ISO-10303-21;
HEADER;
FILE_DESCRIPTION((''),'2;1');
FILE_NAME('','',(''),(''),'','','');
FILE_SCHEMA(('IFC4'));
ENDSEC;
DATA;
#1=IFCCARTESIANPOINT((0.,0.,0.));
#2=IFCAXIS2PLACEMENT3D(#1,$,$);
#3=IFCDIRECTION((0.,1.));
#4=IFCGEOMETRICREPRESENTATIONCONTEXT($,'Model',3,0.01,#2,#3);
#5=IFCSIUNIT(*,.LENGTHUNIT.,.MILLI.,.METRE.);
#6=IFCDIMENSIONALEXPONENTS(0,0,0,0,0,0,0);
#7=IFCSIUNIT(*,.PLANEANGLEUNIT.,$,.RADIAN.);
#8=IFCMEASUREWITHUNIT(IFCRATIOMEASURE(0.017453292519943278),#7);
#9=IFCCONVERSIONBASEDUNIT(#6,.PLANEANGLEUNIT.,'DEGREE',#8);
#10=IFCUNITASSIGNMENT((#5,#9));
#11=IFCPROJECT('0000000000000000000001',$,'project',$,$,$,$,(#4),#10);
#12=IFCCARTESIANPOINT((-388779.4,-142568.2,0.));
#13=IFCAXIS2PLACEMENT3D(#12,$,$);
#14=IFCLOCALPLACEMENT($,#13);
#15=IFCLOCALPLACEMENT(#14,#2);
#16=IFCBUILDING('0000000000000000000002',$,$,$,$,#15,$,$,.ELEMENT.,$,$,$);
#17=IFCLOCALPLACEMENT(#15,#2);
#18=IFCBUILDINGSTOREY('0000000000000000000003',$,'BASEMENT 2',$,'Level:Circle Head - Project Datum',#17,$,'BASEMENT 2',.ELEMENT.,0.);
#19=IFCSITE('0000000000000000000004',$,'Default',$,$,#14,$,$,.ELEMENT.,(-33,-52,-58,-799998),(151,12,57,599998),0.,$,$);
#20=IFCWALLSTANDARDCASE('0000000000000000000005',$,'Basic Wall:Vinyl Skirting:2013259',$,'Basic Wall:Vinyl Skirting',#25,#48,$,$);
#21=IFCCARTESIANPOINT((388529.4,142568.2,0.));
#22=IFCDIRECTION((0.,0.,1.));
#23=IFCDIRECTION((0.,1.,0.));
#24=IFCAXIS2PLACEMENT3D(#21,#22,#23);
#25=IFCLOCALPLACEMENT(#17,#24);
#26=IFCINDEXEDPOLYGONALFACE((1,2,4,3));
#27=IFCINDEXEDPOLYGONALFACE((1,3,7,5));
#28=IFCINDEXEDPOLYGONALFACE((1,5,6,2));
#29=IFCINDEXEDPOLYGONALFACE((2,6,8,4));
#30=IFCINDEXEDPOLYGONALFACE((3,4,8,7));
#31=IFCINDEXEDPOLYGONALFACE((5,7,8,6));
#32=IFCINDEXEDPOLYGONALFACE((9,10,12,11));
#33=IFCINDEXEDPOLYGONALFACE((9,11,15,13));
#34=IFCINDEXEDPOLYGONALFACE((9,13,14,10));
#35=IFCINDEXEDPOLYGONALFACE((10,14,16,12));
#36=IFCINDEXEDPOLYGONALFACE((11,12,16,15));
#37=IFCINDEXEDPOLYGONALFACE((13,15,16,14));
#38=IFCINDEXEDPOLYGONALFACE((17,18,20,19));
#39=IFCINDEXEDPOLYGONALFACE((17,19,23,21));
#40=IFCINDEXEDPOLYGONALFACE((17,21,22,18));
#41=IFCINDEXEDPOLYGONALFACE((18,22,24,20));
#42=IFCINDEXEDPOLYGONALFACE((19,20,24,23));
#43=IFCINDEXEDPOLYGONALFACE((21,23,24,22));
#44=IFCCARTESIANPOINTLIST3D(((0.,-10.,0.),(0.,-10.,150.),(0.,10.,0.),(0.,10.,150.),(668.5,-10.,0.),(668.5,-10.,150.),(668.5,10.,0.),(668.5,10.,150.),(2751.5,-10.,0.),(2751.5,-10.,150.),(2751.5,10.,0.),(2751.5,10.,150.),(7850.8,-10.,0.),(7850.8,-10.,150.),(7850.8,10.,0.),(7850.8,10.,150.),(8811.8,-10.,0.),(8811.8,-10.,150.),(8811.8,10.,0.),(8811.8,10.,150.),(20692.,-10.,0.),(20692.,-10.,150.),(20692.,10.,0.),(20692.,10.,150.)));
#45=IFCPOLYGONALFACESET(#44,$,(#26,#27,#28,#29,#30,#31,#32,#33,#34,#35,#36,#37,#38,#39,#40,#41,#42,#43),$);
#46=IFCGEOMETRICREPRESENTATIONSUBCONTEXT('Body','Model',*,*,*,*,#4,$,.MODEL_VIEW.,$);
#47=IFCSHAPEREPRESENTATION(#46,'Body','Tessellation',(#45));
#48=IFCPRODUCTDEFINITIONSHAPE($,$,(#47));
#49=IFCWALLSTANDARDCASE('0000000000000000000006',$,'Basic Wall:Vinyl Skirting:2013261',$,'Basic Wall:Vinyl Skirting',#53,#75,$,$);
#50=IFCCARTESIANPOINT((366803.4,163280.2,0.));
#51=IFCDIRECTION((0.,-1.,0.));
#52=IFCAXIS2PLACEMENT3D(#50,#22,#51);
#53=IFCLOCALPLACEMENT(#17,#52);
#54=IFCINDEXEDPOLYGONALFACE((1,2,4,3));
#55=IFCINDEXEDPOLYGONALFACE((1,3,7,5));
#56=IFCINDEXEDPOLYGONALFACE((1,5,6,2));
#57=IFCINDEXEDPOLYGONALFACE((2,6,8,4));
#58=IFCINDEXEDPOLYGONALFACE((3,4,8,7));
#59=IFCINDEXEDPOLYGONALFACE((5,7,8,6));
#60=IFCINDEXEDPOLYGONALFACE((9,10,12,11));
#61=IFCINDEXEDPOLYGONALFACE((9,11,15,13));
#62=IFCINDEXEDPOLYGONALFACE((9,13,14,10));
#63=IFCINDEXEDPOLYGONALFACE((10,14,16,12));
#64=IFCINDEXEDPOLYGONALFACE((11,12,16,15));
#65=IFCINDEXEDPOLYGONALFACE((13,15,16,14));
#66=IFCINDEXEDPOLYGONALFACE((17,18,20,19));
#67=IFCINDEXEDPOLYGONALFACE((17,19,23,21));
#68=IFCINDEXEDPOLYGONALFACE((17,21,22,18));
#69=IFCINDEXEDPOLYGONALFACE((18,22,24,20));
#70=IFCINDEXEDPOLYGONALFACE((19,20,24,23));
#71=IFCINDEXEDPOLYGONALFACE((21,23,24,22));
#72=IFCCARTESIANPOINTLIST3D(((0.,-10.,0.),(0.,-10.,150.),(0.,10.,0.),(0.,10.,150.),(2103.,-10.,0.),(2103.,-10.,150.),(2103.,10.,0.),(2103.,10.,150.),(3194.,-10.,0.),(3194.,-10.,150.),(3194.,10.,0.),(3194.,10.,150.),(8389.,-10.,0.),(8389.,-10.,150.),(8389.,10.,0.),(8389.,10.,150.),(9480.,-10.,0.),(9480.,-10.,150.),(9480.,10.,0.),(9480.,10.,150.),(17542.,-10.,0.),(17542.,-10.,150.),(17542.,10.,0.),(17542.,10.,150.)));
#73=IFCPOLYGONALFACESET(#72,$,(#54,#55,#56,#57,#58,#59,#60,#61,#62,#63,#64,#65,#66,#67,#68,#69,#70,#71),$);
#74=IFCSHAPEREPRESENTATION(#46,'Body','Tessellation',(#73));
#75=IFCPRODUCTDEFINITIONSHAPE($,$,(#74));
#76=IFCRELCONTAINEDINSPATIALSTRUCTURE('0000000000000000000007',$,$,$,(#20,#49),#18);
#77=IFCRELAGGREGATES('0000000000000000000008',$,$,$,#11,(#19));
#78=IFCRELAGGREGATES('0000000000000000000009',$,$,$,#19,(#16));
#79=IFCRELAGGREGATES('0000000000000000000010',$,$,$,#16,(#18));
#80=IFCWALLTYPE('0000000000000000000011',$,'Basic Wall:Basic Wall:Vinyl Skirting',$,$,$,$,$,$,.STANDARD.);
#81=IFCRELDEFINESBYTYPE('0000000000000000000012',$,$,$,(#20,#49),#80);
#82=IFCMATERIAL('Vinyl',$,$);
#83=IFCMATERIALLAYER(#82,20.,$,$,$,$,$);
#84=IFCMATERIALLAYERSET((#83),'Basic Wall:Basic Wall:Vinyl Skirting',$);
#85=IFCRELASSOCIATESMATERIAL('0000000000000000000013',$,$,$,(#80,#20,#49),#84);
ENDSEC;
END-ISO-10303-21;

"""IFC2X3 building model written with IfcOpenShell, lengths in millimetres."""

from ifc_helpers import new_model, entity, si_unit, converted_unit, direction, frame, frame_2d, origin, origin_2d_with_axis, place, context, subcontext, project, spatial, rectangle, extrude, material, layer, layer_set, layer_usage, type_object, element, save


model = new_model("IFC2X3")

# Units and contexts
model_context = context("Model", 3, precision=0.01, world=origin(), true_north=direction((0.0, 1.0)))
body_context = subcontext(model_context, "Body", "Model", "MODEL_VIEW")
ifc_project = project(units=[si_unit("LENGTHUNIT", "METRE", prefix="MILLI"), converted_unit("PLANEANGLEUNIT", "DEGREE", entity("IfcRatioMeasure", 0.017453292519943278), si_unit("PLANEANGLEUNIT", "RADIAN"), dimensions=[0, 0, 0, 0, 0, 0, 0])], contexts=[model_context])

# Site, building, storey
site_placement = place(None, frame((-388779.4, -142568.2, 0.0)))
site = spatial("IfcSite", under=ifc_project, at=site_placement, Name="Default", CompositionType="ELEMENT", RefLatitude=(-33, -52, -58, -799998), RefLongitude=(151, 12, 57, 599998), RefElevation=0.0)
building_placement = place(site_placement, origin())
building = spatial("IfcBuilding", under=site, at=building_placement, CompositionType="ELEMENT")
storey_placement = place(building_placement, origin())
storey = spatial("IfcBuildingStorey", under=building, at=storey_placement, Name="BASEMENT 2", ObjectType="Level:Circle Head - Project Datum", LongName="BASEMENT 2", CompositionType="ELEMENT", Elevation=0.0)

# Shared definitions
ifc_material_1 = material(Name="Vinyl")

# Shared definitions
ifc_layer_1 = layer(ifc_material_1, 20.0)
ifc_layer_set_1 = layer_set([ifc_layer_1], Name="Basic Wall:Basic Wall:Vinyl Skirting")
wall_type_1 = type_object("IfcWallType", Name="Basic Wall:Basic Wall:Vinyl Skirting", PredefinedType="STANDARD", material=ifc_layer_set_1)

# Walls, openings
ifc_layer_usage_1 = layer_usage(ifc_layer_set_1, "AXIS2", "NEGATIVE", 10.0)
wall_1_placement = place(storey_placement, frame((388529.4, 142568.2, 0.0), z_axis=(0.0, 0.0, 1.0), x_axis=(0.0, 1.0, 0.0)))
wall_1 = element("IfcWallStandardCase", 1, at=wall_1_placement, inside=storey, type_object=wall_type_1, material=ifc_layer_usage_1, Name="Basic Wall:Vinyl Skirting:2013259", ObjectType="Basic Wall:Vinyl Skirting", context=body_context, shape_type="SweptSolid", body=[
    extrude(rectangle(XDim=20692.0, YDim=20.0, at=frame_2d((10346.0, 0.0), x_axis=(-1.0, 0.0))), origin(), (0.0, 0.0, 1.0), 150.0),
])
opening_1_placement = place(wall_1_placement, origin())
element("IfcOpeningElement", 2, at=opening_1_placement, cuts=wall_1, ObjectType="Opening", context=body_context, shape_type="SweptSolid", body=[
    extrude(rectangle(XDim=2100.0, YDim=2083.0, at=origin_2d_with_axis()), frame((1710.0, -10.0, 1050.0), z_axis=(0.0, 1.0, 0.0), x_axis=(0.0, 0.0, -1.0)), (0.0, 0.0, 1.0), 20.0),
])
opening_2_placement = place(wall_1_placement, origin())
element("IfcOpeningElement", 3, at=opening_2_placement, cuts=wall_1, ObjectType="Opening", context=body_context, shape_type="SweptSolid", body=[
    extrude(rectangle(XDim=2100.0, YDim=961.0, at=frame_2d((0.0, 0.0), x_axis=(1.0, 0.0))), frame((8331.3, -10.0, 1050.0), z_axis=(0.0, 1.0, 0.0), x_axis=(0.0, 0.0, -1.0)), (0.0, 0.0, 1.0), 20.0),
])
ifc_layer_usage_2 = layer_usage(ifc_layer_set_1, "AXIS2", "NEGATIVE", 10.0)
wall_2_placement = place(storey_placement, frame((366803.4, 163280.2, 0.0), z_axis=(0.0, 0.0, 1.0), x_axis=(0.0, -1.0, 0.0)))
wall_2 = element("IfcWallStandardCase", 4, at=wall_2_placement, inside=storey, type_object=wall_type_1, material=ifc_layer_usage_2, Name="Basic Wall:Vinyl Skirting:2013261", ObjectType="Basic Wall:Vinyl Skirting", context=body_context, shape_type="SweptSolid", body=[
    extrude(rectangle(XDim=17542.0, YDim=20.0, at=frame_2d((8771.0, 0.0), x_axis=(-1.0, 0.0))), origin(), (0.0, 0.0, 1.0), 150.0),
])
opening_3_placement = place(wall_2_placement, origin())
element("IfcOpeningElement", 5, at=opening_3_placement, cuts=wall_2, ObjectType="Opening", context=body_context, shape_type="SweptSolid", body=[
    extrude(rectangle(XDim=2185.0, YDim=1091.0, at=origin_2d_with_axis()), frame((2648.5, -10.0, 1092.5), z_axis=(0.0, 1.0, 0.0), x_axis=(0.0, 0.0, -1.0)), (0.0, 0.0, 1.0), 20.0),
])
opening_4_placement = place(wall_2_placement, origin())
element("IfcOpeningElement", 6, at=opening_4_placement, cuts=wall_2, ObjectType="Opening", context=body_context, shape_type="SweptSolid", body=[
    extrude(rectangle(XDim=2185.0, YDim=1091.0, at=origin_2d_with_axis()), frame((8934.5, -10.0, 1092.5), z_axis=(0.0, 1.0, 0.0), x_axis=(0.0, 0.0, -1.0)), (0.0, 0.0, 1.0), 20.0),
])

save(model, "model.ifc")
